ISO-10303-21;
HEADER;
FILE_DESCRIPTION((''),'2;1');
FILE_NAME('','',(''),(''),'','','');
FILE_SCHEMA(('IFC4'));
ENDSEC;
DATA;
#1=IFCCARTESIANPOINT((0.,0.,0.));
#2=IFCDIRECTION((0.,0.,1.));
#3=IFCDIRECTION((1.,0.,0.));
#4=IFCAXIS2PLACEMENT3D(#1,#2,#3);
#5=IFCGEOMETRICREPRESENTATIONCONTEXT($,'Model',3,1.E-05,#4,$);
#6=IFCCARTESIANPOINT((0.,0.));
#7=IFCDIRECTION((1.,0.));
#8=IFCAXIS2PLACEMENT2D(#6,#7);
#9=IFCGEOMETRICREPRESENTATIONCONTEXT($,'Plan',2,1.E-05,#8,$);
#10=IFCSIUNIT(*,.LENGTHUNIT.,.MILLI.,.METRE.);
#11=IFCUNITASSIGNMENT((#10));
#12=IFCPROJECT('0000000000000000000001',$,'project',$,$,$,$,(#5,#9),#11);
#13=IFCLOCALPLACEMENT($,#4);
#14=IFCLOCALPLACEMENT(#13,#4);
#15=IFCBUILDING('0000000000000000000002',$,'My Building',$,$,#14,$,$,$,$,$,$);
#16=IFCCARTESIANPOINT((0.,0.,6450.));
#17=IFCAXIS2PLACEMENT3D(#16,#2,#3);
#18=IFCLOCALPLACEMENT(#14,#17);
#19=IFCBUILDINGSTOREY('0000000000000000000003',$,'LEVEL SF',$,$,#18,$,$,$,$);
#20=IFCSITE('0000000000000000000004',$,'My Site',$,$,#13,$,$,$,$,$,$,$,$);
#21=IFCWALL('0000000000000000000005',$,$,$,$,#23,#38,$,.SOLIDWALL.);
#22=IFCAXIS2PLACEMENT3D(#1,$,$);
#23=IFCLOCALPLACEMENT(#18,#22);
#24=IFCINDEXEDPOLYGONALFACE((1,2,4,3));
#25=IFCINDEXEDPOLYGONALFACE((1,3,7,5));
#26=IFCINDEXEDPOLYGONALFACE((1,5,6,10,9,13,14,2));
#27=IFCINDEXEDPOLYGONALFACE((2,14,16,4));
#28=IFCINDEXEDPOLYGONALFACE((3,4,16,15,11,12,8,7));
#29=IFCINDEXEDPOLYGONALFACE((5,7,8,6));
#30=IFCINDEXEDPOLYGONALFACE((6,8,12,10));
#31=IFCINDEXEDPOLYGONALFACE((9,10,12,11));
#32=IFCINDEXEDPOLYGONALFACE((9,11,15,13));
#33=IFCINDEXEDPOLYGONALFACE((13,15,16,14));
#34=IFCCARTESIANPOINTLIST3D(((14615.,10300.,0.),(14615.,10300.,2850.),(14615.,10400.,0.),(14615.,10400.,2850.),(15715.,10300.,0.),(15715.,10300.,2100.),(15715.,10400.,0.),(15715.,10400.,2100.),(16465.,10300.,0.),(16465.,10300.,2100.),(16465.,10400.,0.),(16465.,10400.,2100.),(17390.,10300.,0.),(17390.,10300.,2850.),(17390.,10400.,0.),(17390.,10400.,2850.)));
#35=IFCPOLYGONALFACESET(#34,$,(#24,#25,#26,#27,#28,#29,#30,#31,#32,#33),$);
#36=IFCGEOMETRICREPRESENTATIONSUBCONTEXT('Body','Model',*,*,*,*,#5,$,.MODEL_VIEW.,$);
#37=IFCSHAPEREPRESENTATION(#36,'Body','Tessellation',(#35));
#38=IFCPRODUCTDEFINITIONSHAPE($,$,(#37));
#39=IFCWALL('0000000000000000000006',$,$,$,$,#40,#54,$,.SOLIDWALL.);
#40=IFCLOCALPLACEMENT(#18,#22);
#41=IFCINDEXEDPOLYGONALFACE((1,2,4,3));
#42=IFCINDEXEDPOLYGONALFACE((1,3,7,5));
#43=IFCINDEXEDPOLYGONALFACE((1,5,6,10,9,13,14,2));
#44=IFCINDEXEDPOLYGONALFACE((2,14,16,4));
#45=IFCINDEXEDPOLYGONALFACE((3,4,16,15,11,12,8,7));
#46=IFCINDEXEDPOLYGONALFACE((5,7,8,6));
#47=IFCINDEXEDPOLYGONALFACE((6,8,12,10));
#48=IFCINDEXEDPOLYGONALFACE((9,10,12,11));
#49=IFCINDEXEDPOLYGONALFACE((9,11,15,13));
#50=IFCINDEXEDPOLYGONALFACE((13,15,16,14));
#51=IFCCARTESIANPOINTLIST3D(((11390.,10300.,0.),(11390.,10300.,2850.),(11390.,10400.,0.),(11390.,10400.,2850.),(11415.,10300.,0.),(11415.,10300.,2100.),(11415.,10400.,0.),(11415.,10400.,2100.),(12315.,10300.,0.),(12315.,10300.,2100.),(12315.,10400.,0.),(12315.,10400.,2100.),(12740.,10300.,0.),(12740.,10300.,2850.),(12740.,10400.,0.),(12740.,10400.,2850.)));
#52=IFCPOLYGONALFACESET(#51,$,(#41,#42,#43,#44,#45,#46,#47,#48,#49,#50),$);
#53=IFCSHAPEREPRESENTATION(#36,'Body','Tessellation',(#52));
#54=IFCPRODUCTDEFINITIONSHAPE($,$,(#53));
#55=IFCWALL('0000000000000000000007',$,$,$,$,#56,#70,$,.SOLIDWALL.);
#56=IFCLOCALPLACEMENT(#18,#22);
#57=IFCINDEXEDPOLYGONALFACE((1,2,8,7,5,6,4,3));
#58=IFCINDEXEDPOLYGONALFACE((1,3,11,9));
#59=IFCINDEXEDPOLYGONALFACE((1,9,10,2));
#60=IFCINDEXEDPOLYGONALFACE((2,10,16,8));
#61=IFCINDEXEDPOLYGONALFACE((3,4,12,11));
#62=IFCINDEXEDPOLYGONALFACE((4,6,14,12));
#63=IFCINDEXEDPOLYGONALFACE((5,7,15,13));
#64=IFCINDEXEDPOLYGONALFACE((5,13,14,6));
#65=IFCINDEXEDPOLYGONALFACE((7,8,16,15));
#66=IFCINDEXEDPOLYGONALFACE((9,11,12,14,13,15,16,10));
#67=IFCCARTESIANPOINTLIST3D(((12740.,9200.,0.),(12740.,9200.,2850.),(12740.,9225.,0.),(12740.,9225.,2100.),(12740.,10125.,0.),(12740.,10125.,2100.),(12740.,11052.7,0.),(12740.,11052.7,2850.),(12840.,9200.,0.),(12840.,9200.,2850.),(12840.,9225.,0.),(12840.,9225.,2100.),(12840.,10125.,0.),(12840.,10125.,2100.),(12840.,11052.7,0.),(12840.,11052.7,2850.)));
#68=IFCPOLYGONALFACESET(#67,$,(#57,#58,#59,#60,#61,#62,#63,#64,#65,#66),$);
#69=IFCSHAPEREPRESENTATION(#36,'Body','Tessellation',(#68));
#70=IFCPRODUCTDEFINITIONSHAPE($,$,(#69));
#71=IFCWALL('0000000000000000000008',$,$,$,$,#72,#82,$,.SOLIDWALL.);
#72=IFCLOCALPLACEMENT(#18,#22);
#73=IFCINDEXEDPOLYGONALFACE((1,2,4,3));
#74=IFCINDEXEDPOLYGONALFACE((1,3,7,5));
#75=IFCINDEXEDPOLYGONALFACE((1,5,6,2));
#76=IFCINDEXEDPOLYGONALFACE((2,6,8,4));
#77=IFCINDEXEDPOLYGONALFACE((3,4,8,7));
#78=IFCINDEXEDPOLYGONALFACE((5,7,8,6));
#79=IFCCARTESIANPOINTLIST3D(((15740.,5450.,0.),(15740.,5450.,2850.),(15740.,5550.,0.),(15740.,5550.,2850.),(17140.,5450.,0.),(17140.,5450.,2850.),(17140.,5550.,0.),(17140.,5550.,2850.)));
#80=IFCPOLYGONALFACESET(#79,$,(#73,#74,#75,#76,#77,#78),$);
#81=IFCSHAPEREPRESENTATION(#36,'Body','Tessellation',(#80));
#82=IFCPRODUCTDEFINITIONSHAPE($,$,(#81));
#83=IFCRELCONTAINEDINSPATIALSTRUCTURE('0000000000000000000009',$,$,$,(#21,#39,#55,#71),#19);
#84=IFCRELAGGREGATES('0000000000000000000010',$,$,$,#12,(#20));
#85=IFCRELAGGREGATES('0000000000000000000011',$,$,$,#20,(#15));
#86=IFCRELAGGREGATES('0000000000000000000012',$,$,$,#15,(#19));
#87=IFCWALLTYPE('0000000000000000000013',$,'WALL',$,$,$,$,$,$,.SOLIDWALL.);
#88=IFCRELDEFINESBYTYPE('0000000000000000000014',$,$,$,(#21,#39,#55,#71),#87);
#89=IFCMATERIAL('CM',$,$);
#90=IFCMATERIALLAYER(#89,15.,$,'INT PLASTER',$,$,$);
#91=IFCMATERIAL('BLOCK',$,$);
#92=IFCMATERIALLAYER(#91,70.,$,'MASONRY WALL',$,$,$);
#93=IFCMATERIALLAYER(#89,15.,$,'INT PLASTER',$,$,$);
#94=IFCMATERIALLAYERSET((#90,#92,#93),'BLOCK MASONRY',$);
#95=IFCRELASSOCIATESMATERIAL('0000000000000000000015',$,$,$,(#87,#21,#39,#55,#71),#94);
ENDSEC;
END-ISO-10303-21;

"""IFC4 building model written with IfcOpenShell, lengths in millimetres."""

from ifc_helpers import new_model, si_unit, frame, origin_with_axes, origin_2d_with_axis, place, context, subcontext, project, spatial, indexed_curve, outline, extrude, material, layer, layer_set, layer_usage, type_object, element, save


model = new_model("IFC4")

# Units and contexts
model_context = context("Model", 3, precision=1e-05, world=origin_with_axes())
plan_context = context("Plan", 2, precision=1e-05, world=origin_2d_with_axis())
body_context = subcontext(model_context, "Body", "Model", "MODEL_VIEW")
ifc_project = project(units=[si_unit("LENGTHUNIT", "METRE", prefix="MILLI")], contexts=[model_context, plan_context])

# Site, building, storey
site_placement = place(None, origin_with_axes())
site = spatial("IfcSite", under=ifc_project, at=site_placement, Name="My Site")
building_placement = place(site_placement, origin_with_axes())
building = spatial("IfcBuilding", under=site, at=building_placement, Name="My Building")
storey_placement = place(building_placement, frame((0.0, 0.0, 6450.0), z_axis=(0.0, 0.0, 1.0), x_axis=(1.0, 0.0, 0.0)))
storey = spatial("IfcBuildingStorey", under=building, at=storey_placement, Name="LEVEL SF")

# Shared definitions
ifc_material_1 = material(Name="CM")
ifc_layer_1 = layer(ifc_material_1, 15.0, Name="INT PLASTER")
ifc_material_2 = material(Name="BLOCK")
ifc_layer_2 = layer(ifc_material_2, 70.0, Name="MASONRY WALL")
ifc_layer_3 = layer(ifc_material_1, 15.0, Name="INT PLASTER")
ifc_layer_set = layer_set([ifc_layer_1, ifc_layer_2, ifc_layer_3], Name="BLOCK MASONRY")
wall_type = type_object("IfcWallType", Name="WALL", PredefinedType="SOLIDWALL", material=ifc_layer_set)

# Walls, openings
ifc_layer_usage_1 = layer_usage(ifc_layer_set, "AXIS2", "POSITIVE", 0.0)
wall_1_placement = place(storey_placement, frame((14615.0, 10400.0, 0.0), z_axis=(0.0, 0.0, 1.0), x_axis=(0.0, -1.0, 0.0)))
wall_1 = element("IfcWall", 1, at=wall_1_placement, inside=storey, type_object=wall_type, material=ifc_layer_usage_1, PredefinedType="SOLIDWALL", context=body_context, shape_type="SweptSolid", body=[
    extrude(outline(indexed_curve([(0.0, 0.0), (0.0, 2775.0), (100.0, 2775.0), (100.0, 0.0), (0.0, 0.0)], self_intersect=False)), origin_with_axes(), (0.0, 0.0, 1.0), 2850.0),
])
opening_1_placement = place(wall_1_placement, frame((0.0, 1850.0, 0.0), z_axis=(0.0, 0.0, 1.0), x_axis=(0.0, -1.0, 0.0)))
element("IfcOpeningElement", 2, at=opening_1_placement, cuts=wall_1, PredefinedType="OPENING", context=body_context, shape_type="SweptSolid", body=[
    extrude(outline(indexed_curve([(0.0, 0.0), (0.0, 400.0), (750.0, 400.0), (750.0, 0.0), (0.0, 0.0)], self_intersect=False)), frame((0.0, -100.0, 0.0), z_axis=(0.0, 0.0, 1.0), x_axis=(1.0, 0.0, 0.0)), (0.0, 0.0, 1.0), 2100.0),
])
ifc_layer_usage_2 = layer_usage(ifc_layer_set, "AXIS2", "POSITIVE", 0.0)
wall_2_placement = place(storey_placement, frame((11390.0, 10400.0, 0.0), z_axis=(0.0, 0.0, 1.0), x_axis=(0.0, -1.0, 0.0)))
wall_2 = element("IfcWall", 3, at=wall_2_placement, inside=storey, type_object=wall_type, material=ifc_layer_usage_2, PredefinedType="SOLIDWALL", context=body_context, shape_type="SweptSolid", body=[
    extrude(outline(indexed_curve([(0.0, 0.0), (0.0, 1350.0), (100.0, 1350.0), (100.0, 0.0), (0.0, 0.0)], self_intersect=False)), origin_with_axes(), (0.0, 0.0, 1.0), 2850.0),
])
opening_2_placement = place(wall_2_placement, frame((100.0, 25.0, 0.0), z_axis=(0.0, 0.0, 1.0), x_axis=(0.0, 1.0, 0.0)))
element("IfcOpeningElement", 4, at=opening_2_placement, cuts=wall_2, PredefinedType="OPENING", context=body_context, shape_type="SweptSolid", body=[
    extrude(outline(indexed_curve([(0.0, 0.0), (0.0, 400.0), (900.0, 400.0), (900.0, 0.0), (0.0, 0.0)], self_intersect=False)), frame((0.0, -100.0, 0.0), z_axis=(0.0, 0.0, 1.0), x_axis=(1.0, 0.0, 0.0)), (0.0, 0.0, 1.0), 2100.0),
])
ifc_layer_usage_3 = layer_usage(ifc_layer_set, "AXIS2", "POSITIVE", 0.0)
wall_3_placement = place(storey_placement, frame((12840.0, 9200.0, 0.0), z_axis=(0.0, 0.0, 1.0), x_axis=(0.0, 1.0, 0.0)))
wall_3 = element("IfcWall", 5, at=wall_3_placement, inside=storey, type_object=wall_type, material=ifc_layer_usage_3, PredefinedType="SOLIDWALL", context=body_context, shape_type="SweptSolid", body=[
    extrude(outline(indexed_curve([(0.0, 0.0), (0.0, 100.0), (1852.7, 100.0), (1852.7, 0.0), (0.0, 0.0)], self_intersect=False)), origin_with_axes(), (0.0, 0.0, 1.0), 2850.0),
])
opening_3_placement = place(wall_3_placement, frame((925.0, 100.0, 0.0), z_axis=(0.0, 0.0, 1.0), x_axis=(-1.0, 0.0, 0.0)))
element("IfcOpeningElement", 6, at=opening_3_placement, cuts=wall_3, PredefinedType="OPENING", context=body_context, shape_type="SweptSolid", body=[
    extrude(outline(indexed_curve([(0.0, 0.0), (0.0, 400.0), (900.0, 400.0), (900.0, 0.0), (0.0, 0.0)], self_intersect=False)), frame((0.0, -100.0, 0.0), z_axis=(0.0, 0.0, 1.0), x_axis=(1.0, 0.0, 0.0)), (0.0, 0.0, 1.0), 2100.0),
])

# Wall
ifc_layer_usage_4 = layer_usage(ifc_layer_set, "AXIS2", "POSITIVE", 0.0)
wall_4_placement = place(storey_placement, frame((15740.0, 5550.0, 0.0), z_axis=(0.0, 0.0, 1.0), x_axis=(0.0, -1.0, 0.0)))
element("IfcWall", 7, at=wall_4_placement, inside=storey, type_object=wall_type, material=ifc_layer_usage_4, PredefinedType="SOLIDWALL", context=body_context, shape_type="SweptSolid", body=[
    extrude(outline(indexed_curve([(0.0, 0.0), (0.0, 1400.0), (100.0, 1400.0), (100.0, 0.0), (0.0, 0.0)], self_intersect=False)), origin_with_axes(), (0.0, 0.0, 1.0), 2850.0),
])

save(model, "model.ifc")
